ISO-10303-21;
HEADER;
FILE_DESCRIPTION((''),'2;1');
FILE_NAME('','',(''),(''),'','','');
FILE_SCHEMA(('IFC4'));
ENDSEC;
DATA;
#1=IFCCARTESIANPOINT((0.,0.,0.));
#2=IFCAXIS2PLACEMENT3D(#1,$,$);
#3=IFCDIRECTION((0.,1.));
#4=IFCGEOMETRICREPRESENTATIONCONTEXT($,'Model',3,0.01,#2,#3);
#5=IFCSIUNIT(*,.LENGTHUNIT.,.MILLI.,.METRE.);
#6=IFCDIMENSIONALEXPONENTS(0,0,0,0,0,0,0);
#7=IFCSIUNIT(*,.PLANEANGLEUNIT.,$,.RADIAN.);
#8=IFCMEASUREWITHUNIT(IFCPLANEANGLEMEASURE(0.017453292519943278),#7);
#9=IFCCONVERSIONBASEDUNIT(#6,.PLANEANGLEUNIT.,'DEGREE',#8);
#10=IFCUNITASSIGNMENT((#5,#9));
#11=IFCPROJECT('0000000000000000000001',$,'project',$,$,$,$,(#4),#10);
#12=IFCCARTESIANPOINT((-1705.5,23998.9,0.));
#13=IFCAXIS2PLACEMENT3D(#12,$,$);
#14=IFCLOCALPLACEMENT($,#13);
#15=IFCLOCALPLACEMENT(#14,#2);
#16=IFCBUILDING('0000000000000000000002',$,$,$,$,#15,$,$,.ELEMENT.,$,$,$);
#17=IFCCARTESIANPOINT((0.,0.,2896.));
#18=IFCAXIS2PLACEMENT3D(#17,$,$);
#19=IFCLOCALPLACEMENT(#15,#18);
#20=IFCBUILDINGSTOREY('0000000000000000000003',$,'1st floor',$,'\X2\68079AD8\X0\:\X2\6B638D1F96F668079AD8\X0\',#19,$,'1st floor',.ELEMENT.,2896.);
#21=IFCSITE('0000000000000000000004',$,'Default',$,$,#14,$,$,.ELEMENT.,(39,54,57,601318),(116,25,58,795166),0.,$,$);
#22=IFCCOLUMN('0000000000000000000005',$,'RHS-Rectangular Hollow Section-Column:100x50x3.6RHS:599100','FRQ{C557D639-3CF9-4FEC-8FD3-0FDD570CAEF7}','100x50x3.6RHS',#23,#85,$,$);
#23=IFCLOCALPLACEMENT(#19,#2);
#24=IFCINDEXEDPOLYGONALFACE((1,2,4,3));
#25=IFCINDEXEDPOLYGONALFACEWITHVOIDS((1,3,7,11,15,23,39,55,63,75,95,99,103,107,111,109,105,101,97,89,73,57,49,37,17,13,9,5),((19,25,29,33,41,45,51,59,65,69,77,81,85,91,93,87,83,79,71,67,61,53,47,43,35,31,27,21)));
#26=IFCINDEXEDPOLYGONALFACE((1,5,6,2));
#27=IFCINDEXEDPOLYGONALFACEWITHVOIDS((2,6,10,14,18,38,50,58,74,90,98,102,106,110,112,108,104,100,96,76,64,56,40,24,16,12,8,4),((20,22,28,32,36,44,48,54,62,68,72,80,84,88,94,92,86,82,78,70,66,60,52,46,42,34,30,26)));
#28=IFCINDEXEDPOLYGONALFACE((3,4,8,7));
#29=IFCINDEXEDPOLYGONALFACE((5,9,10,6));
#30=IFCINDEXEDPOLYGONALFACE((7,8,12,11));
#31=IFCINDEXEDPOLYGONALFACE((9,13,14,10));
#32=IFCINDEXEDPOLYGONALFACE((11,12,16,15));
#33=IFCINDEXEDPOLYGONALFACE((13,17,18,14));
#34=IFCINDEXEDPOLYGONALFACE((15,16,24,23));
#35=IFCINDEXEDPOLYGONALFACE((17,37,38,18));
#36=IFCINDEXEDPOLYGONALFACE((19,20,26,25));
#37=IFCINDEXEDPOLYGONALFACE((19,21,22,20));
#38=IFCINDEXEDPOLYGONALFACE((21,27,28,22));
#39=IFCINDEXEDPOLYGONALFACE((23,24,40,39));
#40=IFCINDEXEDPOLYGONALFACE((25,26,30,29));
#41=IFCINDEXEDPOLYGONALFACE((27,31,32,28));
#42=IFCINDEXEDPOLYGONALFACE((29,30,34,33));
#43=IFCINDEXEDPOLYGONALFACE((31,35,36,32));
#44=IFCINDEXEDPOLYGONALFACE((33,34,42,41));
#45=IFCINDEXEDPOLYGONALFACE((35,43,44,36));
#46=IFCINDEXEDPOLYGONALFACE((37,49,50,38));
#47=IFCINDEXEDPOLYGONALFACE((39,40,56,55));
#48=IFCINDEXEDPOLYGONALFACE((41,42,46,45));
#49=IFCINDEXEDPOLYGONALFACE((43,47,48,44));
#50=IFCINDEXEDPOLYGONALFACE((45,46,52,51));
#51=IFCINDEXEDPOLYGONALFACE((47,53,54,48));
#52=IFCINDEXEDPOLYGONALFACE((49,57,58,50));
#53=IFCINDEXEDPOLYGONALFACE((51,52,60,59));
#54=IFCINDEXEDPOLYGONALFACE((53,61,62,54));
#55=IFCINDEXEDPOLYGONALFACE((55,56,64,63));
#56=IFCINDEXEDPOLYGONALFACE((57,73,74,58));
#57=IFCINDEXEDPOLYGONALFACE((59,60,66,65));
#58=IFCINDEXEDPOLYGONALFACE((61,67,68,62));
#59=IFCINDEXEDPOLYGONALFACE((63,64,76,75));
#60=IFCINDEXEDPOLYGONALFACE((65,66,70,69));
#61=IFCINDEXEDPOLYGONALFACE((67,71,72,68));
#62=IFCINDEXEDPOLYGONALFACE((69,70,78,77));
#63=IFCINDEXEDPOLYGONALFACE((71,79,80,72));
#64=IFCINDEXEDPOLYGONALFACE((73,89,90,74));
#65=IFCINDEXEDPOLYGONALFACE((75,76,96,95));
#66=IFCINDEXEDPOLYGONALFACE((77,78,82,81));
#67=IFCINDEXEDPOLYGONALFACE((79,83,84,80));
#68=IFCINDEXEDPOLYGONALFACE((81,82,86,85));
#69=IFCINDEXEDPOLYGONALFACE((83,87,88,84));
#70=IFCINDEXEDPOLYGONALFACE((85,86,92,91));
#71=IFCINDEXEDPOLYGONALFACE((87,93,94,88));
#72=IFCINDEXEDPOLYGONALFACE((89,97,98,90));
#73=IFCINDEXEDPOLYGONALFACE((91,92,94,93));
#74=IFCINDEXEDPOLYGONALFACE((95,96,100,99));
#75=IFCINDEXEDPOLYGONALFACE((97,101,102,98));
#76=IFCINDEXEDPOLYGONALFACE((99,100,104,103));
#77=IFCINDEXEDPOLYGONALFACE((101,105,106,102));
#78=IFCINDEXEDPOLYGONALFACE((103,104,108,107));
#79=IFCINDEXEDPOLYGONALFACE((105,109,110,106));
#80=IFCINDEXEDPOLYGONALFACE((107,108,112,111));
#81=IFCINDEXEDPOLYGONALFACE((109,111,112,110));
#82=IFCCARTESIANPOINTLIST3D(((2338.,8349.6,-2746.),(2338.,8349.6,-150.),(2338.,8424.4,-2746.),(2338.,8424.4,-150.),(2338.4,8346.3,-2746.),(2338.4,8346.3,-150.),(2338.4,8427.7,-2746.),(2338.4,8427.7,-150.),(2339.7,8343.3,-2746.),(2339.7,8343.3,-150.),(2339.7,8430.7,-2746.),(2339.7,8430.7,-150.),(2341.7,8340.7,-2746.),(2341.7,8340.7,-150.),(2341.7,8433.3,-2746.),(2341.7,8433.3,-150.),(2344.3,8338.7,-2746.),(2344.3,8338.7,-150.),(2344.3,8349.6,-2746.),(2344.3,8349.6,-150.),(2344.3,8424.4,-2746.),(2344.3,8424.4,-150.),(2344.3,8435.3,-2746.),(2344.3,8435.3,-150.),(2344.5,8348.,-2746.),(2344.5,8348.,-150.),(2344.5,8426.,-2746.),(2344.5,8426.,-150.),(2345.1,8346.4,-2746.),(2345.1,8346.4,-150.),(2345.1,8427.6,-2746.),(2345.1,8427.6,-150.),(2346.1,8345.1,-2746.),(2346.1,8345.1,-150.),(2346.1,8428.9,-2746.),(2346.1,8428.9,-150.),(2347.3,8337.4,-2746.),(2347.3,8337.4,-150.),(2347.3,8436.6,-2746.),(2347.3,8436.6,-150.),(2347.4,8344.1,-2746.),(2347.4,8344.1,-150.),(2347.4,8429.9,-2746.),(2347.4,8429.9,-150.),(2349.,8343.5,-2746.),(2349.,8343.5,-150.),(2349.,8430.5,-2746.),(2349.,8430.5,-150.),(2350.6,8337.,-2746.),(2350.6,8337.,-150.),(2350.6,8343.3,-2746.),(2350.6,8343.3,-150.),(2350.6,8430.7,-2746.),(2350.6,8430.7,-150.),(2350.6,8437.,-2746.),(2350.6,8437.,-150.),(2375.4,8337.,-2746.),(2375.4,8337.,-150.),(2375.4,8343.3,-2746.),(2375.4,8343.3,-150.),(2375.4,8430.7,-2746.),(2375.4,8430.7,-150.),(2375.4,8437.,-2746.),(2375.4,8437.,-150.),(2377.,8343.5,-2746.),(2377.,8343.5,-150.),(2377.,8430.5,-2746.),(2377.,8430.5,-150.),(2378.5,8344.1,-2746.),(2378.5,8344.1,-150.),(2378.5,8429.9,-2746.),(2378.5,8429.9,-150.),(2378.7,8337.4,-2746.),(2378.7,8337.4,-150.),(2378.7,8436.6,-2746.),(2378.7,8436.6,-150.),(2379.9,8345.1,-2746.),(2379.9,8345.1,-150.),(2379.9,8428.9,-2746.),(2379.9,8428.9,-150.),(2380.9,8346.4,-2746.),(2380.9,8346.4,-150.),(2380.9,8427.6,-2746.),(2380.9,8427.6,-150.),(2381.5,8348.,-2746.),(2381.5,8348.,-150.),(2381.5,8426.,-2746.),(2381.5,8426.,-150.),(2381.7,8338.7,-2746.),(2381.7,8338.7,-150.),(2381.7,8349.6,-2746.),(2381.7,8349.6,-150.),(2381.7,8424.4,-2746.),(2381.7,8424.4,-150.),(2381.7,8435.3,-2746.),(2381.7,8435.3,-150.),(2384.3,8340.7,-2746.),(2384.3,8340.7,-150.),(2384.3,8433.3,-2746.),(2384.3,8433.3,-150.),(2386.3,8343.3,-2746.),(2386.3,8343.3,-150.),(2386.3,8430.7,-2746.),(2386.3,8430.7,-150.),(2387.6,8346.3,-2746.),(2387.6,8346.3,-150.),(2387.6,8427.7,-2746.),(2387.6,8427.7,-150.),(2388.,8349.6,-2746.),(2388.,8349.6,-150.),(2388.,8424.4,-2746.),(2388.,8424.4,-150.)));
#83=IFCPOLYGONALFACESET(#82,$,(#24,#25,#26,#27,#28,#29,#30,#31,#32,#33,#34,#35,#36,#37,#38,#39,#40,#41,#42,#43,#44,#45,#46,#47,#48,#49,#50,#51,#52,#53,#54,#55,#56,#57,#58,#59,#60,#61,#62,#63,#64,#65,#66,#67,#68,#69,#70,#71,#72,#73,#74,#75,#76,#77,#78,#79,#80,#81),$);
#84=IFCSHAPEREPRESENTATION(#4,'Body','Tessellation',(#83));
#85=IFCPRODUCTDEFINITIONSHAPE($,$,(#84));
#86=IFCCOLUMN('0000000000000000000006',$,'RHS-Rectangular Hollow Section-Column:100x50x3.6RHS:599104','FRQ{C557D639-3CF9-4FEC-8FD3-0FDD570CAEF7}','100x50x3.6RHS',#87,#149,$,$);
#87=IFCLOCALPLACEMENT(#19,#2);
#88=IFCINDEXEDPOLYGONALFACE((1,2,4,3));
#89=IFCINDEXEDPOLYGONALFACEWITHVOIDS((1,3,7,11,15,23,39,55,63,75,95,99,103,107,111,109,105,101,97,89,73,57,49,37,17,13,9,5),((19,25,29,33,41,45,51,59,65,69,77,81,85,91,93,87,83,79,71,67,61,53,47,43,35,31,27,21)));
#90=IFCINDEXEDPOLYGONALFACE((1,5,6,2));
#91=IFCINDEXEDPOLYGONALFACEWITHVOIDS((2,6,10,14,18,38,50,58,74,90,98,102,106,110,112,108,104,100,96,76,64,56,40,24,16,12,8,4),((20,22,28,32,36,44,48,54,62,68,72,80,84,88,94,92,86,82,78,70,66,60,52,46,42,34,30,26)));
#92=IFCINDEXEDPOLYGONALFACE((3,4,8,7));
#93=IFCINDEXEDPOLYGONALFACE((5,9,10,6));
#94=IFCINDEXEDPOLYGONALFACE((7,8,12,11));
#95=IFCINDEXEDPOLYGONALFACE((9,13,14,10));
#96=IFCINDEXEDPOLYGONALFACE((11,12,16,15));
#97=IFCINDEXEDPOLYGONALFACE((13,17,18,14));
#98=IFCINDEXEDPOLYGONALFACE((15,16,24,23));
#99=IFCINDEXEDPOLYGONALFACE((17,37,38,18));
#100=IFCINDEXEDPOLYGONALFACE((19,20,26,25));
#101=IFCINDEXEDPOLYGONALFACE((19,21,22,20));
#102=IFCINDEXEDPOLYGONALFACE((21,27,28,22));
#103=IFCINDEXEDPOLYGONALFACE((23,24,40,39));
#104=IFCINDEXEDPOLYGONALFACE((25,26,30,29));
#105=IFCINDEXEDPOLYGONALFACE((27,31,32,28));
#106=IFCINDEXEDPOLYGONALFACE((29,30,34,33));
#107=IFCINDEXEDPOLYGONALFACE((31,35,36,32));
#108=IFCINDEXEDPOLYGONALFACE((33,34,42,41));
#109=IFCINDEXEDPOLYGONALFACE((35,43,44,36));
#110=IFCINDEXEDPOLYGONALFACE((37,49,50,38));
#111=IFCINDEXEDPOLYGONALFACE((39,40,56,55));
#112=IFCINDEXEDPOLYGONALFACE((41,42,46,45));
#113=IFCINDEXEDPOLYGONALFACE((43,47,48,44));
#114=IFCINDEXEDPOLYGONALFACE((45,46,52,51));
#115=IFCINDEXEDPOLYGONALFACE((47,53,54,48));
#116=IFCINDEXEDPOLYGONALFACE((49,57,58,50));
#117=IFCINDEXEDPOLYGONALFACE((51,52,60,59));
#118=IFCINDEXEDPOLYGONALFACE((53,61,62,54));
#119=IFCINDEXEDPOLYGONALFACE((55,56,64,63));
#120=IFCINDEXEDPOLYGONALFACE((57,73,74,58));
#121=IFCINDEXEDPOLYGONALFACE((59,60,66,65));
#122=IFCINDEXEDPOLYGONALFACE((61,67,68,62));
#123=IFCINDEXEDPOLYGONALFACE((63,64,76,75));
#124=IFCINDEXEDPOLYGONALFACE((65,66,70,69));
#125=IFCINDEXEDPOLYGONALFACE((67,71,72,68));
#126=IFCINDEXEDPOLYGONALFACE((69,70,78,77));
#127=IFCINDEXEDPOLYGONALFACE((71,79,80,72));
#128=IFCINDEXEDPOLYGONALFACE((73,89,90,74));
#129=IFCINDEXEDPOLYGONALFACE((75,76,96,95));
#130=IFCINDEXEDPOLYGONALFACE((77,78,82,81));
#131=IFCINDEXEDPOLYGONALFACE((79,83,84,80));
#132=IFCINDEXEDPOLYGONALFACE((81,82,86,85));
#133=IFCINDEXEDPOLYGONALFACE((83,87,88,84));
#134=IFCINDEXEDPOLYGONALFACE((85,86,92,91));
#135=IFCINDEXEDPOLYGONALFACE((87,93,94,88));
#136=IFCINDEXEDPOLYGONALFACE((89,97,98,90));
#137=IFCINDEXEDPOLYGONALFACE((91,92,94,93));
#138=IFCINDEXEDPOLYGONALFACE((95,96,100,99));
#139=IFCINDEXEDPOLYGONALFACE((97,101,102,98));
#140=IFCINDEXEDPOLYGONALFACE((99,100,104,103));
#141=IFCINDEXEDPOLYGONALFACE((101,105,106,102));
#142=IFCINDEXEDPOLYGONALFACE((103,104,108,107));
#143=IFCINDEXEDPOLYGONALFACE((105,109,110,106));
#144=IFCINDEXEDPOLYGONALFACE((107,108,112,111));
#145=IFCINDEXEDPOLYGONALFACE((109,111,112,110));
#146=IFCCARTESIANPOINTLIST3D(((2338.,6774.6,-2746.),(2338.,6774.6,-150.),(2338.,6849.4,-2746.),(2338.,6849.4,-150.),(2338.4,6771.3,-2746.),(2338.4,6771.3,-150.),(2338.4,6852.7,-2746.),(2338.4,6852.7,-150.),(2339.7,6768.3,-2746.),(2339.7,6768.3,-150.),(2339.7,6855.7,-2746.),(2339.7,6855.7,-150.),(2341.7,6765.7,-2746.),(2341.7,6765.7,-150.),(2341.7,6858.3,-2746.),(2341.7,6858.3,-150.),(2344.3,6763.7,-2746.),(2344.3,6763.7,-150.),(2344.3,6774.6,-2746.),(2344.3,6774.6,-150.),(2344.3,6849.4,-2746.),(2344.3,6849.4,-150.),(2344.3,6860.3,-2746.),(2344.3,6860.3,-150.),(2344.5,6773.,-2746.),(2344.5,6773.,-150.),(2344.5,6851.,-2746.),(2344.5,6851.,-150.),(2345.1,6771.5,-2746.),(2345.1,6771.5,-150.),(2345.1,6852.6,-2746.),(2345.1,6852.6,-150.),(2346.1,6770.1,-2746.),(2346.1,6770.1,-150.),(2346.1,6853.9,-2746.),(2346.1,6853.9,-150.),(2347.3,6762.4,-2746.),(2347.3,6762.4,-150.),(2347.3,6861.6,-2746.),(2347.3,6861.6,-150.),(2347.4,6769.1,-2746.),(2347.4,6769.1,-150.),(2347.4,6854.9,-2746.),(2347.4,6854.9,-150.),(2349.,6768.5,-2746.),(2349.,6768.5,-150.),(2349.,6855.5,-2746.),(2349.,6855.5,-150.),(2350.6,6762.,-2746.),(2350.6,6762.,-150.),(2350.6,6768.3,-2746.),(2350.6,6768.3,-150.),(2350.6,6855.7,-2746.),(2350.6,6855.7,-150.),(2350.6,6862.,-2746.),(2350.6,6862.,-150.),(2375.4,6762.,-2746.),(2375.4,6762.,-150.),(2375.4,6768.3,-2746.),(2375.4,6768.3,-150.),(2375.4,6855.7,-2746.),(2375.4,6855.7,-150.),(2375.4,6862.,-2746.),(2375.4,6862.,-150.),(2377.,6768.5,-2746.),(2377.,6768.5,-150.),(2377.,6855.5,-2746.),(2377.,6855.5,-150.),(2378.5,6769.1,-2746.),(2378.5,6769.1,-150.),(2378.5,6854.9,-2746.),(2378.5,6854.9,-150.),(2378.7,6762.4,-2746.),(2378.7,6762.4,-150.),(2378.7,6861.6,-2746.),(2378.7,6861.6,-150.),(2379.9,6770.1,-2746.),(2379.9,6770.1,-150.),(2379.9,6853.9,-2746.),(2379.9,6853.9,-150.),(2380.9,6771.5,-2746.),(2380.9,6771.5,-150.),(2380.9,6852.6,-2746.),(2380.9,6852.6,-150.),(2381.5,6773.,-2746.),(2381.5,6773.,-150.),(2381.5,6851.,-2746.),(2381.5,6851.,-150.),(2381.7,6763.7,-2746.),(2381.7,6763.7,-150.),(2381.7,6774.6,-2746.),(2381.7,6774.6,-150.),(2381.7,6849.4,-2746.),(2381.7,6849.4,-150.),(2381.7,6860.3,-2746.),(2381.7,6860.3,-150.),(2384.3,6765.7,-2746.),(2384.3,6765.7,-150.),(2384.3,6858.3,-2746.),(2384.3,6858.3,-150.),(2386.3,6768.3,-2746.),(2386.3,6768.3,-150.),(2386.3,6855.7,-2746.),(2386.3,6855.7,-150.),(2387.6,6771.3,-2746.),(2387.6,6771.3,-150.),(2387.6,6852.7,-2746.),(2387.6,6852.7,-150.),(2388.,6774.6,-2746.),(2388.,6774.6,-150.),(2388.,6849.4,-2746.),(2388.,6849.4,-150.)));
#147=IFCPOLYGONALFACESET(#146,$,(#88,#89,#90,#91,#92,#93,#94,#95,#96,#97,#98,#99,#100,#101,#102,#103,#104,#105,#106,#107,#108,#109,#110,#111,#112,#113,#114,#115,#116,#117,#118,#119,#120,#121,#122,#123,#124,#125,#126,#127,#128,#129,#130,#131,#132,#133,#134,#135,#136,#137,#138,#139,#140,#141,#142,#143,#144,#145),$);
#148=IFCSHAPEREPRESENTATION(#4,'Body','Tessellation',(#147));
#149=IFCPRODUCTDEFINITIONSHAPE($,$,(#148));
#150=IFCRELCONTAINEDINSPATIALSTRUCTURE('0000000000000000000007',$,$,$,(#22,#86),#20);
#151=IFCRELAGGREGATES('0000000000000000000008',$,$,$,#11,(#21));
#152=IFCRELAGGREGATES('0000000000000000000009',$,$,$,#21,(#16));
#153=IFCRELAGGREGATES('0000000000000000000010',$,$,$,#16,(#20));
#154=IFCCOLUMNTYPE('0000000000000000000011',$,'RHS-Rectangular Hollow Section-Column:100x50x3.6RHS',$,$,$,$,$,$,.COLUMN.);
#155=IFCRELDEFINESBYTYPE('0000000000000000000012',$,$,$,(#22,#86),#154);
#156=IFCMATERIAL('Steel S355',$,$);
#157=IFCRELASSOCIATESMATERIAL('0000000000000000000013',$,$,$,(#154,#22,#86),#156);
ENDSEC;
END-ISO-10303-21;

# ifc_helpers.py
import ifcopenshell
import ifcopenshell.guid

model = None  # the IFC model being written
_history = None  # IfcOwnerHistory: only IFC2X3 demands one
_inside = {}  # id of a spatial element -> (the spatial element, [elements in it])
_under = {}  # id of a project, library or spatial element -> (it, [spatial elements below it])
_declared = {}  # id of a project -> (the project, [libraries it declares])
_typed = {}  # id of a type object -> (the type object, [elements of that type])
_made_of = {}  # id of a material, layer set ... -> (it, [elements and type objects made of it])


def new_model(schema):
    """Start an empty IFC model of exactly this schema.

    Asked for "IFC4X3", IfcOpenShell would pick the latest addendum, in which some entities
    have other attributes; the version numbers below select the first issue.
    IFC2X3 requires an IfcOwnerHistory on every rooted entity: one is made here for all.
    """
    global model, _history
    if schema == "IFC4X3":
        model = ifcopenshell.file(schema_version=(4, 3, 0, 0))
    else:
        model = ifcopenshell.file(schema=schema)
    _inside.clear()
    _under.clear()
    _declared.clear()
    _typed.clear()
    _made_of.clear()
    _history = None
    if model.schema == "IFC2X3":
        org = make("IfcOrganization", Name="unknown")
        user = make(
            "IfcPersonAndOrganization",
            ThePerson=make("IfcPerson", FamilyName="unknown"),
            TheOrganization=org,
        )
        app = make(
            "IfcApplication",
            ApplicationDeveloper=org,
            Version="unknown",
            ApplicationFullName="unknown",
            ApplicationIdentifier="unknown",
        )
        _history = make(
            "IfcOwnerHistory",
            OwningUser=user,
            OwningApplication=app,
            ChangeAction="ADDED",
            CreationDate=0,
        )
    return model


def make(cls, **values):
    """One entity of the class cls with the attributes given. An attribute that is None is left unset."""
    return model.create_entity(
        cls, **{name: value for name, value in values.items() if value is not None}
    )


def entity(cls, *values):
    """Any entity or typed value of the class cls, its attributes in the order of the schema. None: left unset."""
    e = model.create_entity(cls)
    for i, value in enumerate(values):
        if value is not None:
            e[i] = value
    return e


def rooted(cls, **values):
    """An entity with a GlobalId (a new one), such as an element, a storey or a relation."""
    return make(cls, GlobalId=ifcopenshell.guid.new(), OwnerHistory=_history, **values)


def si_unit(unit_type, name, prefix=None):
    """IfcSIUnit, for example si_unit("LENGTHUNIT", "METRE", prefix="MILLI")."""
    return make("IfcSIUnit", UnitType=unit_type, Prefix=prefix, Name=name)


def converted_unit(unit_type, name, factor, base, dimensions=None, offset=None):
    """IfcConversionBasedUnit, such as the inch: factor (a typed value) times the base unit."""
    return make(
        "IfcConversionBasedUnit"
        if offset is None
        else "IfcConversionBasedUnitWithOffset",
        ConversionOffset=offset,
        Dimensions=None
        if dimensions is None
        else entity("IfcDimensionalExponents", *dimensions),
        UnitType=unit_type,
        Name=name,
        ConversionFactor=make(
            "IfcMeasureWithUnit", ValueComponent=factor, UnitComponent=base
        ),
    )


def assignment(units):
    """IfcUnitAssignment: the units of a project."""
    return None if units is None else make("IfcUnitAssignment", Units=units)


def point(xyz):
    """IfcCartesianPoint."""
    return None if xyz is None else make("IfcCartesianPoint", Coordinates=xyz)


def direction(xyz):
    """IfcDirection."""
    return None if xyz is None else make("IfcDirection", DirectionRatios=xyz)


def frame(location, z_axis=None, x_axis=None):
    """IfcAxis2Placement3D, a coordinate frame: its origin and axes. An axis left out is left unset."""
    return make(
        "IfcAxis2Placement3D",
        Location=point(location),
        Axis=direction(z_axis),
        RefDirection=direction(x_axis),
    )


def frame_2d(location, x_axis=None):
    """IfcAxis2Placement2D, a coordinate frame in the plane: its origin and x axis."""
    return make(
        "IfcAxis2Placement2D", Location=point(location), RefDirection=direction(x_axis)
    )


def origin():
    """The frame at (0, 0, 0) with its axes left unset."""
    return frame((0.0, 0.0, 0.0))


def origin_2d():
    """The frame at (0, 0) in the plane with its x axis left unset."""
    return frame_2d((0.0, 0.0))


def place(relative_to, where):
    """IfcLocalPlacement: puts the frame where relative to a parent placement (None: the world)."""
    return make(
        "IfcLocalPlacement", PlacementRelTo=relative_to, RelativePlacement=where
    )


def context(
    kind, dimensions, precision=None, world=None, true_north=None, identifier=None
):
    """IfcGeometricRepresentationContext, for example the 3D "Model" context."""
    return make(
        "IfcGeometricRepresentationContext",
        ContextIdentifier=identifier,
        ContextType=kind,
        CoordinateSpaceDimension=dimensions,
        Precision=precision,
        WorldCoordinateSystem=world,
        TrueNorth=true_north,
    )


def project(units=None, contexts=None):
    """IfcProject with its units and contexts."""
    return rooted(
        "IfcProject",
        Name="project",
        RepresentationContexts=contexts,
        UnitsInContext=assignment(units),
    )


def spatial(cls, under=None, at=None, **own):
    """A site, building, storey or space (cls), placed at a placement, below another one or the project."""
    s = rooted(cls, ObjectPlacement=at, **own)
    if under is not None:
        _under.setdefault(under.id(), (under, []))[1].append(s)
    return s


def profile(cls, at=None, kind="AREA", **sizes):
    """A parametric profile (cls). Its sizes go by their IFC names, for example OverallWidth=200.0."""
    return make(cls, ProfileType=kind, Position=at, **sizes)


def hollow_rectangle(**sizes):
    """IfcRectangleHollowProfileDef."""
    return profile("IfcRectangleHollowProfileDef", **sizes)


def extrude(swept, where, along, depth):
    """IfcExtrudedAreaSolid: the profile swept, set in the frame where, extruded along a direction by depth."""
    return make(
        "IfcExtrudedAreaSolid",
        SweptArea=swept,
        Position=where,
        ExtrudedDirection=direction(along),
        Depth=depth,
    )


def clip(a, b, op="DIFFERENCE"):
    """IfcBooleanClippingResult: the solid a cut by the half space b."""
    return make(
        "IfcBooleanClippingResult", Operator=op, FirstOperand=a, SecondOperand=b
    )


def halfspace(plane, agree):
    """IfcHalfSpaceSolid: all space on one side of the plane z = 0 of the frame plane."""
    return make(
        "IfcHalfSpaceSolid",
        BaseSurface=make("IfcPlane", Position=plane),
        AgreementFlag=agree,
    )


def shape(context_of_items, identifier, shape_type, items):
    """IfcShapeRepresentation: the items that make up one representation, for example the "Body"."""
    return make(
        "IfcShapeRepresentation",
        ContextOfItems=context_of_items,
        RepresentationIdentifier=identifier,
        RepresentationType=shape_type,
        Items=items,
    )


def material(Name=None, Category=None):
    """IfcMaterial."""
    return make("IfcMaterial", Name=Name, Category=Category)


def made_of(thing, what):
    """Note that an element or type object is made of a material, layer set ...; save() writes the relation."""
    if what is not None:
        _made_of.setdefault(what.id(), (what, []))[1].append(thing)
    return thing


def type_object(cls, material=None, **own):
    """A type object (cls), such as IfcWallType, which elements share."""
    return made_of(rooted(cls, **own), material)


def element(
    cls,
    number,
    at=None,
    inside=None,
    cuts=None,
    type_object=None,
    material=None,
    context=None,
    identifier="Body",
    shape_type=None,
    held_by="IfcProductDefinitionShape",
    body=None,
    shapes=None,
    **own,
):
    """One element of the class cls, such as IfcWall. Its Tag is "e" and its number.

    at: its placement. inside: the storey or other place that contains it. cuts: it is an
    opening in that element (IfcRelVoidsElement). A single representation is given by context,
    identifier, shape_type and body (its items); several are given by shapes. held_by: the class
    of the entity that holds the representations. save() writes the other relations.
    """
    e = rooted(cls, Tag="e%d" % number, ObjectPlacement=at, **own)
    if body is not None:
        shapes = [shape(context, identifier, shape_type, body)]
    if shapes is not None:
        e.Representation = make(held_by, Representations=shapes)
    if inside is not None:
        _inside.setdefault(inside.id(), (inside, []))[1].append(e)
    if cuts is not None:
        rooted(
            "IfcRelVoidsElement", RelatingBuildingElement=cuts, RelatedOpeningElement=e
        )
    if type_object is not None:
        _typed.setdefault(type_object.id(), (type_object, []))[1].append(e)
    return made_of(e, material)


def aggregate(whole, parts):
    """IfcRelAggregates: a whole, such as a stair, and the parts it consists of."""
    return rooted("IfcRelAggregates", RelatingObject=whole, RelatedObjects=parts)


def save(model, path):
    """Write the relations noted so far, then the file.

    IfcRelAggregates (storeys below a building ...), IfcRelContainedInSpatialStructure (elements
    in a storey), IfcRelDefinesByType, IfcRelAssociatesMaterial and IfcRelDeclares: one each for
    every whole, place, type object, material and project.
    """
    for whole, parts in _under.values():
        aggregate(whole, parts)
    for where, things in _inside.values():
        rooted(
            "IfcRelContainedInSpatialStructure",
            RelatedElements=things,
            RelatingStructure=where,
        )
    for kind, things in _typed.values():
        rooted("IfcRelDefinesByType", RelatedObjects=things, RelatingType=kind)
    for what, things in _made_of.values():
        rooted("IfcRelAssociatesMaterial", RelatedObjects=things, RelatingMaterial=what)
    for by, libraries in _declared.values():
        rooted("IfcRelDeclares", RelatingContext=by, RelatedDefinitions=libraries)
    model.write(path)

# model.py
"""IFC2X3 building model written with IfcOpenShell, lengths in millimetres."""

from ifc_helpers import new_model, entity, si_unit, converted_unit, direction, frame, origin, origin_2d, place, context, project, spatial, hollow_rectangle, extrude, clip, halfspace, material, type_object, element, save


model = new_model("IFC2X3")

# Units and contexts
model_context = context("Model", 3, precision=0.01, world=origin(), true_north=direction((0.0, 1.0)))
ifc_project = project(units=[si_unit("LENGTHUNIT", "METRE", prefix="MILLI"), converted_unit("PLANEANGLEUNIT", "DEGREE", entity("IfcPlaneAngleMeasure", 0.017453292519943278), si_unit("PLANEANGLEUNIT", "RADIAN"), dimensions=[0, 0, 0, 0, 0, 0, 0])], contexts=[model_context])

# Site, building, storey
site_placement = place(None, frame((-1705.5, 23998.9, 0.0)))
site = spatial("IfcSite", under=ifc_project, at=site_placement, Name="Default", CompositionType="ELEMENT", RefLatitude=(39, 54, 57, 601318), RefLongitude=(116, 25, 58, 795166), RefElevation=0.0)
building_placement = place(site_placement, origin())
building = spatial("IfcBuilding", under=site, at=building_placement, CompositionType="ELEMENT")
storey_placement = place(building_placement, frame((0.0, 0.0, 2896.0)))
storey = spatial("IfcBuildingStorey", under=building, at=storey_placement, Name="1st floor", ObjectType="标高:正负零标高", LongName="1st floor", CompositionType="ELEMENT", Elevation=2896.0)

# Columns
ifc_material_1 = material(Name="Steel S355")
column_type_1 = type_object("IfcColumnType", Name="RHS-Rectangular Hollow Section-Column:100x50x3.6RHS", PredefinedType="COLUMN", material=ifc_material_1)
column_1_placement = place(storey_placement, frame((2363.0, 8387.0, -150.0), z_axis=(0.0, 0.0, 1.0), x_axis=(-1.0, 0.0, 0.0)))
element("IfcColumn", 1, at=column_1_placement, inside=storey, type_object=column_type_1, material=ifc_material_1, Name="RHS-Rectangular Hollow Section-Column:100x50x3.6RHS:599100", Description="FRQ{C557D639-3CF9-4FEC-8FD3-0FDD570CAEF7}", ObjectType="100x50x3.6RHS", context=model_context, shape_type="Clipping", body=[
    clip(extrude(hollow_rectangle(XDim=50.0, YDim=100.0, WallThickness=6.3, InnerFilletRadius=6.3, OuterFilletRadius=12.6, at=origin_2d()), origin(), (0.0, 0.0, -1.0), 2651.9), halfspace(frame((2363.0, 8387.0, -2596.0), z_axis=(0.0, 0.0, 1.0), x_axis=(-1.0, 0.0, 0.0)), True)),
])
column_2_placement = place(storey_placement, frame((2363.0, 6812.0, -150.0), z_axis=(0.0, 0.0, 1.0), x_axis=(-1.0, 0.0, 0.0)))
element("IfcColumn", 2, at=column_2_placement, inside=storey, type_object=column_type_1, material=ifc_material_1, Name="RHS-Rectangular Hollow Section-Column:100x50x3.6RHS:599104", Description="FRQ{C557D639-3CF9-4FEC-8FD3-0FDD570CAEF7}", ObjectType="100x50x3.6RHS", context=model_context, shape_type="Clipping", body=[
    clip(extrude(hollow_rectangle(XDim=50.0, YDim=100.0, WallThickness=6.3, InnerFilletRadius=6.3, OuterFilletRadius=12.6, at=origin_2d()), origin(), (0.0, 0.0, -1.0), 2651.9), halfspace(frame((2363.0, 6812.0, -2596.0), z_axis=(0.0, 0.0, 1.0), x_axis=(-1.0, 0.0, 0.0)), True)),
])

save(model, "model.ifc")
